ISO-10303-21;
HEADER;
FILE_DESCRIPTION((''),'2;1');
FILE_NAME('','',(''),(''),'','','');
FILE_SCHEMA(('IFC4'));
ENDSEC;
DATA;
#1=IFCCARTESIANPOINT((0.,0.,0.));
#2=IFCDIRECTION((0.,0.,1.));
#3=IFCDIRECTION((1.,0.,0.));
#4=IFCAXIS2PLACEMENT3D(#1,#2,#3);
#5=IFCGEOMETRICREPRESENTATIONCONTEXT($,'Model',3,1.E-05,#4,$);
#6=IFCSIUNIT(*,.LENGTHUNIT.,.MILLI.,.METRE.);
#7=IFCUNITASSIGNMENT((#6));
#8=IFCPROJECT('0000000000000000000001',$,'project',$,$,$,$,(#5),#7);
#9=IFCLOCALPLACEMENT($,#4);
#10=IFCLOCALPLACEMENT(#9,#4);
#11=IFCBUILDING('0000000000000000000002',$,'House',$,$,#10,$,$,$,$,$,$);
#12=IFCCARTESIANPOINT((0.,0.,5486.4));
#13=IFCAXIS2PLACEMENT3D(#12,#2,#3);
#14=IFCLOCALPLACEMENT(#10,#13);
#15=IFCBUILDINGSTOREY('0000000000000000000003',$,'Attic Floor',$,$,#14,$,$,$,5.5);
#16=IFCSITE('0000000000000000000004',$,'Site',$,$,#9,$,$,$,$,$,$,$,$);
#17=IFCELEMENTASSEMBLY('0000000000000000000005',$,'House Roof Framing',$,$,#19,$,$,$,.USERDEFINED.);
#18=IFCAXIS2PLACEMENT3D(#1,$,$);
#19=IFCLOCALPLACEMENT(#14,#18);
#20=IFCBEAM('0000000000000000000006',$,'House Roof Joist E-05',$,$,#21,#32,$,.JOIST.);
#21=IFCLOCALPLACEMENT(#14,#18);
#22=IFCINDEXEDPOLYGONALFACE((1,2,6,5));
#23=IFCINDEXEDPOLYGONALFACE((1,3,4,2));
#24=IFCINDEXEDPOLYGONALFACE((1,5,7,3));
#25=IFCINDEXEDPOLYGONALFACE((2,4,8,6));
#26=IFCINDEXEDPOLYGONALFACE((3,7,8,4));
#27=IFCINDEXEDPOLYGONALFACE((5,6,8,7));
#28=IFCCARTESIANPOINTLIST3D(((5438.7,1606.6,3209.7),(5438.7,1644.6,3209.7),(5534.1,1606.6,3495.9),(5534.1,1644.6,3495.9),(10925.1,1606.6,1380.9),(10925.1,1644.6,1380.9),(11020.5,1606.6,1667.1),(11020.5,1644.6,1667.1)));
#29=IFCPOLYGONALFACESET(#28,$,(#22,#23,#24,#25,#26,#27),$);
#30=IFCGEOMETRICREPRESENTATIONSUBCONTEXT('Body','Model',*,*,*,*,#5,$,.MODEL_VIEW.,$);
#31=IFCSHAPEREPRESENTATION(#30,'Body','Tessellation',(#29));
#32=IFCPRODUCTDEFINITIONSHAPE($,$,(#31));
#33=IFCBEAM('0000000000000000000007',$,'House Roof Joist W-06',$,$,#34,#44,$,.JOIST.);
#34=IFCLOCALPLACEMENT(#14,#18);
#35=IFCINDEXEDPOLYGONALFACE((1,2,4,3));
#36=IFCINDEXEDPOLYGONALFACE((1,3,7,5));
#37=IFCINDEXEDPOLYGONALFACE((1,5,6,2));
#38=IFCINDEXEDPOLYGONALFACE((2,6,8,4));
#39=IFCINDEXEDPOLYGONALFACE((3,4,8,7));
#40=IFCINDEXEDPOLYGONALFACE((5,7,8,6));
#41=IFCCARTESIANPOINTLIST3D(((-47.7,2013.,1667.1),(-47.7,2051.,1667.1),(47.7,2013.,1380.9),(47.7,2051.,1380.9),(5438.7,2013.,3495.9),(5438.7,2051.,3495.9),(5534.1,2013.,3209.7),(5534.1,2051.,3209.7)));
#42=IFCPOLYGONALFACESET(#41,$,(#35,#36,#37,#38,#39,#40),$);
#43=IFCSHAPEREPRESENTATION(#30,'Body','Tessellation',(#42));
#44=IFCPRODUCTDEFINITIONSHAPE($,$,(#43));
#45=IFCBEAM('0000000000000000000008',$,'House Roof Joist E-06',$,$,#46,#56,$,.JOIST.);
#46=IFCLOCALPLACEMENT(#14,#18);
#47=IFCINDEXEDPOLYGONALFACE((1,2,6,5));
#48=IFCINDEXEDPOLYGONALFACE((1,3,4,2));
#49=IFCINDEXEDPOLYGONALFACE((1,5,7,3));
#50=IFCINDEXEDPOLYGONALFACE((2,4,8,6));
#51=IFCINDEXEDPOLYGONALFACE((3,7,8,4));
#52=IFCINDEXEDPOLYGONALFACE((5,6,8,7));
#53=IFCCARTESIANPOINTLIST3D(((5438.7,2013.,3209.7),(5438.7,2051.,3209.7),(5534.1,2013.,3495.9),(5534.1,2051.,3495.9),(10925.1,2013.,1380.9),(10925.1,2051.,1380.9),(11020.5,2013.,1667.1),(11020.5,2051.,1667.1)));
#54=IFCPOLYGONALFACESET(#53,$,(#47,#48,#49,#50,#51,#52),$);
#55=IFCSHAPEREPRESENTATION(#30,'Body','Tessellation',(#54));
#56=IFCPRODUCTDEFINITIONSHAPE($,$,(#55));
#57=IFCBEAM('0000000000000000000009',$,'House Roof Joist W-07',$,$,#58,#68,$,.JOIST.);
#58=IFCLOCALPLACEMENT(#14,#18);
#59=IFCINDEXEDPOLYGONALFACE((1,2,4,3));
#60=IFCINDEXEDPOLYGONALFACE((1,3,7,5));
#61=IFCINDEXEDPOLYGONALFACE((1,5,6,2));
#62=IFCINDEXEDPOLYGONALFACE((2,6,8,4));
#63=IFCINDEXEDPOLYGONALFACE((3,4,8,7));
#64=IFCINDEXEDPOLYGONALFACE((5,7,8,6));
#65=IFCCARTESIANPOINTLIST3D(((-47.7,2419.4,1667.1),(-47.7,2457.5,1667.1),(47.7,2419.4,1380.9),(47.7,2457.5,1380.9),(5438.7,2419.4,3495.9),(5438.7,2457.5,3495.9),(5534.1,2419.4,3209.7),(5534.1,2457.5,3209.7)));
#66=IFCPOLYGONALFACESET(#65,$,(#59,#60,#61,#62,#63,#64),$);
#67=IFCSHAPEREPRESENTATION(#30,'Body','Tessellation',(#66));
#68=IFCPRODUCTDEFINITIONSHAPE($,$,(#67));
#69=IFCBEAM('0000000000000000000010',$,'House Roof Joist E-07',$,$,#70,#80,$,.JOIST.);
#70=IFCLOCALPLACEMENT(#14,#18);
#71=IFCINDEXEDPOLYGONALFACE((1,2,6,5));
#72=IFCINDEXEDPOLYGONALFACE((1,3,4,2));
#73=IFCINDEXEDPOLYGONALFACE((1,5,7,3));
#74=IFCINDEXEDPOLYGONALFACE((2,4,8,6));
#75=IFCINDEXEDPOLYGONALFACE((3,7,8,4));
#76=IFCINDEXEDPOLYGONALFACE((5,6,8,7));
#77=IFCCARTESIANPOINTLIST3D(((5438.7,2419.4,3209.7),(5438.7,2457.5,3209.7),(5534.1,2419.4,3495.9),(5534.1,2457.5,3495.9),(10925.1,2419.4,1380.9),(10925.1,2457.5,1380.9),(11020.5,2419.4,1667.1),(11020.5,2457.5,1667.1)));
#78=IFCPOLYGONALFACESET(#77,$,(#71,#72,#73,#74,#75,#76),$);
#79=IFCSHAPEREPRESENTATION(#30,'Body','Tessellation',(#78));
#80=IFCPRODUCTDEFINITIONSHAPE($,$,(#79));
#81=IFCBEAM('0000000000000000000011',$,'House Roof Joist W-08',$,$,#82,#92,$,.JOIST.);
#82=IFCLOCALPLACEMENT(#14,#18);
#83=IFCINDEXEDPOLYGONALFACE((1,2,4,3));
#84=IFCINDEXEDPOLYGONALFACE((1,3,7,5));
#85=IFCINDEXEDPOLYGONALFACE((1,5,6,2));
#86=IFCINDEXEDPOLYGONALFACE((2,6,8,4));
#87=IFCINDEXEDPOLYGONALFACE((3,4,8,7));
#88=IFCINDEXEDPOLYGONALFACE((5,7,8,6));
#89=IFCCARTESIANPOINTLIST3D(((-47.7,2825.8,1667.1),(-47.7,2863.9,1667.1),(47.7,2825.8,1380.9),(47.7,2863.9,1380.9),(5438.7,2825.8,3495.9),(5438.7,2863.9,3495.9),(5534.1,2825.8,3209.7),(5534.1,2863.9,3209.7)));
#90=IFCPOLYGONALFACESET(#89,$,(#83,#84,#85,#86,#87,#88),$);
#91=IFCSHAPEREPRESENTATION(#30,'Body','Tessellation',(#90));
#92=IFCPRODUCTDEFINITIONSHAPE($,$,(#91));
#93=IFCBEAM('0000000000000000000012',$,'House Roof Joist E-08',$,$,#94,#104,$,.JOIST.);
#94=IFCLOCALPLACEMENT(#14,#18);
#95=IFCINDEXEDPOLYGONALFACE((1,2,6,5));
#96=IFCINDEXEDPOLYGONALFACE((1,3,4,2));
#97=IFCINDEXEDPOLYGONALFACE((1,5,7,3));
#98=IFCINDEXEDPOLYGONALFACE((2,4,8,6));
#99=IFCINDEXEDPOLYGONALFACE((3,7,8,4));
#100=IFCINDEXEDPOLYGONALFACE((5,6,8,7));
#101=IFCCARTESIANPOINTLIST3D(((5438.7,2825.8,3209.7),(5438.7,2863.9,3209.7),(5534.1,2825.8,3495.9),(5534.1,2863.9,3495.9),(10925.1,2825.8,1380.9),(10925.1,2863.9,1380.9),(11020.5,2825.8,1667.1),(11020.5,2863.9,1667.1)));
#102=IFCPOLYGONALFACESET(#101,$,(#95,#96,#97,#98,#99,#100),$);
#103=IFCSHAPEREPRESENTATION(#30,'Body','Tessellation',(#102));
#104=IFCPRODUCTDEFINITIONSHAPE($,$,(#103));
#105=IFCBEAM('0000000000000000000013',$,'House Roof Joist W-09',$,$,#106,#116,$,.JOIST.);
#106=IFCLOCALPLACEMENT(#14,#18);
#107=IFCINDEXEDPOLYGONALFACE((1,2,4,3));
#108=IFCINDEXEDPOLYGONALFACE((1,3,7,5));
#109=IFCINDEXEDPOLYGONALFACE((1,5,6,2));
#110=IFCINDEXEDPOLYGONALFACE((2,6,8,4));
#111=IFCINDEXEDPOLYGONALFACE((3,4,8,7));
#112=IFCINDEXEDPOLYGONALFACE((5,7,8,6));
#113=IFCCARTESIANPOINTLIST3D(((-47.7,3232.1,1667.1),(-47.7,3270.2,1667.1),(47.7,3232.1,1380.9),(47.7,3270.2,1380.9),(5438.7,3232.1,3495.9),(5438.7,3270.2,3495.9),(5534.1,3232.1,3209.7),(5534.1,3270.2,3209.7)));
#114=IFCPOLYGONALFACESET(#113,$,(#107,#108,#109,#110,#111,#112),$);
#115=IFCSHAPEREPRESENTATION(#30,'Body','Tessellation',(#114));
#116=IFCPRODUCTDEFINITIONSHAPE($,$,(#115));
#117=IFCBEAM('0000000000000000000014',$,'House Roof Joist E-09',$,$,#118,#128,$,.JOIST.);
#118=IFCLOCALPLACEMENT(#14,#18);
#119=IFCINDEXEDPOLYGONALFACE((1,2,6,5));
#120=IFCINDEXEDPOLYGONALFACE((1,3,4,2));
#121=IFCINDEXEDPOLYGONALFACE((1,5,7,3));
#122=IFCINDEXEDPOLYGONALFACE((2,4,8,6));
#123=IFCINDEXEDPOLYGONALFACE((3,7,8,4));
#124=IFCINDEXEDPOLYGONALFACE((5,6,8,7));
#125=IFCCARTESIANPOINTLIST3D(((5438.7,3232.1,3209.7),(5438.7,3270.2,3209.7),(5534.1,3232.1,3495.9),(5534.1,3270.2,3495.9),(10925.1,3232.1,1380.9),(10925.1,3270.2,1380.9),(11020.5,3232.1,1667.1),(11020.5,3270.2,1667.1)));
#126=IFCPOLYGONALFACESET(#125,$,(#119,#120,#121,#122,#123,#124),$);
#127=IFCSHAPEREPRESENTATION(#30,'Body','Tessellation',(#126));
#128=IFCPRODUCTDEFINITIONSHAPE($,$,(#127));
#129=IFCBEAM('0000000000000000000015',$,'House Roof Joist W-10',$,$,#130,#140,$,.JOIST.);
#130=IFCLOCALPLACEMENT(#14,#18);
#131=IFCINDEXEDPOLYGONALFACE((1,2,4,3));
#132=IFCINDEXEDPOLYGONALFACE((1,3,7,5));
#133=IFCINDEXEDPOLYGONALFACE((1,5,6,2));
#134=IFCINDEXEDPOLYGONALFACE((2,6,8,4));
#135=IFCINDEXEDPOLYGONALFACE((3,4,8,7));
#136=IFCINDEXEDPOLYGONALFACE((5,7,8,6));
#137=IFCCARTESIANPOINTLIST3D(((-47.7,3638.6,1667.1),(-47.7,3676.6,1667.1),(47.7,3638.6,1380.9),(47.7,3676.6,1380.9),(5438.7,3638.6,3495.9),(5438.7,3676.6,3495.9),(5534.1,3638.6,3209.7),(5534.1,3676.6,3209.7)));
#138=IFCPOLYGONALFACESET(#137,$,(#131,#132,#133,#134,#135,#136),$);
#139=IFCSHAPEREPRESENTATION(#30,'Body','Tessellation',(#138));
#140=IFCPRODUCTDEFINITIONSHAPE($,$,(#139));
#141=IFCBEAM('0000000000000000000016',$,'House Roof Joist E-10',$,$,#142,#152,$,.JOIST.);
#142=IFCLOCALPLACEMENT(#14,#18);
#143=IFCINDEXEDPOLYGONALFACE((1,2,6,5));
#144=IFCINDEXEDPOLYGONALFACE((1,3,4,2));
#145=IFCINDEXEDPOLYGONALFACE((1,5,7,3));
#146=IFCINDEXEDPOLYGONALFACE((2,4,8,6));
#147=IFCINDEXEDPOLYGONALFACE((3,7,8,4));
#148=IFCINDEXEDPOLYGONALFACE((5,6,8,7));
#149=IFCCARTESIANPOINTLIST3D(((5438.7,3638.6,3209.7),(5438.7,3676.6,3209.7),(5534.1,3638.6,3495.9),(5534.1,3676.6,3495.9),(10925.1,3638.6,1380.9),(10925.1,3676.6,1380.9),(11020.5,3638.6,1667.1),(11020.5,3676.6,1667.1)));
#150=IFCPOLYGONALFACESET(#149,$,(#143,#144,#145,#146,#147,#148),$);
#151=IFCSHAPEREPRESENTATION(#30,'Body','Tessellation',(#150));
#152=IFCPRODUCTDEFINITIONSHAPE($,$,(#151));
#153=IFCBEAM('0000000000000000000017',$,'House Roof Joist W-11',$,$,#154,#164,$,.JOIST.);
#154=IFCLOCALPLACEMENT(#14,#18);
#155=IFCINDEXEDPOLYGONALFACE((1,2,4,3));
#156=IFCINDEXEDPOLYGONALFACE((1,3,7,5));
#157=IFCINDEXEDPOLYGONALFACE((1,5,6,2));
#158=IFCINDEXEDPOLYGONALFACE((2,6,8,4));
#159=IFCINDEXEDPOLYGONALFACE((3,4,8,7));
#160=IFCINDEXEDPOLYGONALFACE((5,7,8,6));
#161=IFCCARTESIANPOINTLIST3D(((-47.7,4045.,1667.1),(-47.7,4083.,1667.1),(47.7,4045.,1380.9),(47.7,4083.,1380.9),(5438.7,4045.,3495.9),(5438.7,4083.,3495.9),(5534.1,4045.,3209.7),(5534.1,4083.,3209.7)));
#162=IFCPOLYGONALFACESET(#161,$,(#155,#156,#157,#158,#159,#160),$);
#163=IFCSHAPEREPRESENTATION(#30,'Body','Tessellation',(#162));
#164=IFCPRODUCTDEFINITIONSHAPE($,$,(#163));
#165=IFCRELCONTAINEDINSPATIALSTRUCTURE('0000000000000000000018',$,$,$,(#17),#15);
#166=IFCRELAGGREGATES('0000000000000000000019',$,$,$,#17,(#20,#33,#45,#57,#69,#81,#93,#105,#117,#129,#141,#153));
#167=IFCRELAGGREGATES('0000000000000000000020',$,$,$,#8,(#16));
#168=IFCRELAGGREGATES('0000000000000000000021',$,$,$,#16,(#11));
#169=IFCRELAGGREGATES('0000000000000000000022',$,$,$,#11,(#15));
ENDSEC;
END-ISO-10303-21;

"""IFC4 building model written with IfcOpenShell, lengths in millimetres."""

from ifc_helpers import new_model, si_unit, frame, origin_with_axes, origin_2d, place, context, subcontext, project, spatial, rectangle, extrude, element, aggregate, save


model = new_model("IFC4")

# Units and contexts
model_context = context("Model", 3, precision=1e-05, world=origin_with_axes())
body_context = subcontext(model_context, "Body", "Model", "MODEL_VIEW")
ifc_project = project(units=[si_unit("LENGTHUNIT", "METRE", prefix="MILLI")], contexts=[model_context])

# Site, building, storey
site_placement = place(None, origin_with_axes())
site = spatial("IfcSite", under=ifc_project, at=site_placement, Name="Site")
building_placement = place(site_placement, origin_with_axes())
building = spatial("IfcBuilding", under=site, at=building_placement, Name="House")
storey_placement = place(building_placement, frame((0.0, 0.0, 5486.4), z_axis=(0.0, 0.0, 1.0), x_axis=(1.0, 0.0, 0.0)))
storey = spatial("IfcBuildingStorey", under=building, at=storey_placement, Name="Attic Floor", Elevation=5.5)

# Element assembly, beams
assembly_1_placement = place(storey_placement, frame((0.0, 0.0, -5486.4), z_axis=(0.0, 0.0, 1.0), x_axis=(1.0, 0.0, 0.0)))
assembly_1 = element("IfcElementAssembly", 1, at=assembly_1_placement, inside=storey, Name="House Roof Framing", PredefinedType="USERDEFINED")
beam_1_placement = place(assembly_1_placement, frame((5486.4, 1625.6, 8839.2), z_axis=(0.948683, 0.0, -0.316228), x_axis=(0.0, 1.0, 0.0)))
beam_1 = element("IfcBeam", 2, at=beam_1_placement, Name="House Roof Joist E-05", PredefinedType="JOIST", context=body_context, shape_type="SweptSolid", body=[
    extrude(rectangle(XDim=38.1, YDim=301.6, at=origin_2d()), origin_with_axes(), (0.0, 0.0, 1.0), 5783.2),
])
beam_2_placement = place(assembly_1_placement, frame((5486.4, 2032.0, 8839.2), z_axis=(-0.948683, 0.0, -0.316228), x_axis=(0.0, 1.0, 0.0)))
beam_2 = element("IfcBeam", 3, at=beam_2_placement, Name="House Roof Joist W-06", PredefinedType="JOIST", context=body_context, shape_type="SweptSolid", body=[
    extrude(rectangle(XDim=38.1, YDim=301.6, at=origin_2d()), origin_with_axes(), (0.0, 0.0, 1.0), 5783.2),
])
beam_3_placement = place(assembly_1_placement, frame((5486.4, 2032.0, 8839.2), z_axis=(0.948683, 0.0, -0.316228), x_axis=(0.0, 1.0, 0.0)))
beam_3 = element("IfcBeam", 4, at=beam_3_placement, Name="House Roof Joist E-06", PredefinedType="JOIST", context=body_context, shape_type="SweptSolid", body=[
    extrude(rectangle(XDim=38.1, YDim=301.6, at=origin_2d()), origin_with_axes(), (0.0, 0.0, 1.0), 5783.2),
])
beam_4_placement = place(assembly_1_placement, frame((5486.4, 2438.4, 8839.2), z_axis=(-0.948683, 0.0, -0.316228), x_axis=(0.0, 1.0, 0.0)))
beam_4 = element("IfcBeam", 5, at=beam_4_placement, Name="House Roof Joist W-07", PredefinedType="JOIST", context=body_context, shape_type="SweptSolid", body=[
    extrude(rectangle(XDim=38.1, YDim=301.6, at=origin_2d()), origin_with_axes(), (0.0, 0.0, 1.0), 5783.2),
])
beam_5_placement = place(assembly_1_placement, frame((5486.4, 2438.4, 8839.2), z_axis=(0.948683, 0.0, -0.316228), x_axis=(0.0, 1.0, 0.0)))
beam_5 = element("IfcBeam", 6, at=beam_5_placement, Name="House Roof Joist E-07", PredefinedType="JOIST", context=body_context, shape_type="SweptSolid", body=[
    extrude(rectangle(XDim=38.1, YDim=301.6, at=origin_2d()), origin_with_axes(), (0.0, 0.0, 1.0), 5783.2),
])
beam_6_placement = place(assembly_1_placement, frame((5486.4, 2844.8, 8839.2), z_axis=(-0.948683, 0.0, -0.316228), x_axis=(0.0, 1.0, 0.0)))
beam_6 = element("IfcBeam", 7, at=beam_6_placement, Name="House Roof Joist W-08", PredefinedType="JOIST", context=body_context, shape_type="SweptSolid", body=[
    extrude(rectangle(XDim=38.1, YDim=301.6, at=origin_2d()), origin_with_axes(), (0.0, 0.0, 1.0), 5783.2),
])
beam_7_placement = place(assembly_1_placement, frame((5486.4, 2844.8, 8839.2), z_axis=(0.948683, 0.0, -0.316228), x_axis=(0.0, 1.0, 0.0)))
beam_7 = element("IfcBeam", 8, at=beam_7_placement, Name="House Roof Joist E-08", PredefinedType="JOIST", context=body_context, shape_type="SweptSolid", body=[
    extrude(rectangle(XDim=38.1, YDim=301.6, at=origin_2d()), origin_with_axes(), (0.0, 0.0, 1.0), 5783.2),
])
beam_8_placement = place(assembly_1_placement, frame((5486.4, 3251.2, 8839.2), z_axis=(-0.948683, 0.0, -0.316228), x_axis=(0.0, 1.0, 0.0)))
beam_8 = element("IfcBeam", 9, at=beam_8_placement, Name="House Roof Joist W-09", PredefinedType="JOIST", context=body_context, shape_type="SweptSolid", body=[
    extrude(rectangle(XDim=38.1, YDim=301.6, at=origin_2d()), origin_with_axes(), (0.0, 0.0, 1.0), 5783.2),
])
beam_9_placement = place(assembly_1_placement, frame((5486.4, 3251.2, 8839.2), z_axis=(0.948683, 0.0, -0.316228), x_axis=(0.0, 1.0, 0.0)))
beam_9 = element("IfcBeam", 10, at=beam_9_placement, Name="House Roof Joist E-09", PredefinedType="JOIST", context=body_context, shape_type="SweptSolid", body=[
    extrude(rectangle(XDim=38.1, YDim=301.6, at=origin_2d()), origin_with_axes(), (0.0, 0.0, 1.0), 5783.2),
])
beam_10_placement = place(assembly_1_placement, frame((5486.4, 3657.6, 8839.2), z_axis=(-0.948683, 0.0, -0.316228), x_axis=(0.0, 1.0, 0.0)))
beam_10 = element("IfcBeam", 11, at=beam_10_placement, Name="House Roof Joist W-10", PredefinedType="JOIST", context=body_context, shape_type="SweptSolid", body=[
    extrude(rectangle(XDim=38.1, YDim=301.6, at=origin_2d()), origin_with_axes(), (0.0, 0.0, 1.0), 5783.2),
])
beam_11_placement = place(assembly_1_placement, frame((5486.4, 3657.6, 8839.2), z_axis=(0.948683, 0.0, -0.316228), x_axis=(0.0, 1.0, 0.0)))
beam_11 = element("IfcBeam", 12, at=beam_11_placement, Name="House Roof Joist E-10", PredefinedType="JOIST", context=body_context, shape_type="SweptSolid", body=[
    extrude(rectangle(XDim=38.1, YDim=301.6, at=origin_2d()), origin_with_axes(), (0.0, 0.0, 1.0), 5783.2),
])
beam_12_placement = place(assembly_1_placement, frame((5486.4, 4064.0, 8839.2), z_axis=(-0.948683, 0.0, -0.316228), x_axis=(0.0, 1.0, 0.0)))
beam_12 = element("IfcBeam", 13, at=beam_12_placement, Name="House Roof Joist W-11", PredefinedType="JOIST", context=body_context, shape_type="SweptSolid", body=[
    extrude(rectangle(XDim=38.1, YDim=301.6, at=origin_2d()), origin_with_axes(), (0.0, 0.0, 1.0), 5783.2),
])
aggregate(assembly_1, [beam_1, beam_2, beam_3, beam_4, beam_5, beam_6, beam_7, beam_8, beam_9, beam_10, beam_11, beam_12])

save(model, "model.ifc")
